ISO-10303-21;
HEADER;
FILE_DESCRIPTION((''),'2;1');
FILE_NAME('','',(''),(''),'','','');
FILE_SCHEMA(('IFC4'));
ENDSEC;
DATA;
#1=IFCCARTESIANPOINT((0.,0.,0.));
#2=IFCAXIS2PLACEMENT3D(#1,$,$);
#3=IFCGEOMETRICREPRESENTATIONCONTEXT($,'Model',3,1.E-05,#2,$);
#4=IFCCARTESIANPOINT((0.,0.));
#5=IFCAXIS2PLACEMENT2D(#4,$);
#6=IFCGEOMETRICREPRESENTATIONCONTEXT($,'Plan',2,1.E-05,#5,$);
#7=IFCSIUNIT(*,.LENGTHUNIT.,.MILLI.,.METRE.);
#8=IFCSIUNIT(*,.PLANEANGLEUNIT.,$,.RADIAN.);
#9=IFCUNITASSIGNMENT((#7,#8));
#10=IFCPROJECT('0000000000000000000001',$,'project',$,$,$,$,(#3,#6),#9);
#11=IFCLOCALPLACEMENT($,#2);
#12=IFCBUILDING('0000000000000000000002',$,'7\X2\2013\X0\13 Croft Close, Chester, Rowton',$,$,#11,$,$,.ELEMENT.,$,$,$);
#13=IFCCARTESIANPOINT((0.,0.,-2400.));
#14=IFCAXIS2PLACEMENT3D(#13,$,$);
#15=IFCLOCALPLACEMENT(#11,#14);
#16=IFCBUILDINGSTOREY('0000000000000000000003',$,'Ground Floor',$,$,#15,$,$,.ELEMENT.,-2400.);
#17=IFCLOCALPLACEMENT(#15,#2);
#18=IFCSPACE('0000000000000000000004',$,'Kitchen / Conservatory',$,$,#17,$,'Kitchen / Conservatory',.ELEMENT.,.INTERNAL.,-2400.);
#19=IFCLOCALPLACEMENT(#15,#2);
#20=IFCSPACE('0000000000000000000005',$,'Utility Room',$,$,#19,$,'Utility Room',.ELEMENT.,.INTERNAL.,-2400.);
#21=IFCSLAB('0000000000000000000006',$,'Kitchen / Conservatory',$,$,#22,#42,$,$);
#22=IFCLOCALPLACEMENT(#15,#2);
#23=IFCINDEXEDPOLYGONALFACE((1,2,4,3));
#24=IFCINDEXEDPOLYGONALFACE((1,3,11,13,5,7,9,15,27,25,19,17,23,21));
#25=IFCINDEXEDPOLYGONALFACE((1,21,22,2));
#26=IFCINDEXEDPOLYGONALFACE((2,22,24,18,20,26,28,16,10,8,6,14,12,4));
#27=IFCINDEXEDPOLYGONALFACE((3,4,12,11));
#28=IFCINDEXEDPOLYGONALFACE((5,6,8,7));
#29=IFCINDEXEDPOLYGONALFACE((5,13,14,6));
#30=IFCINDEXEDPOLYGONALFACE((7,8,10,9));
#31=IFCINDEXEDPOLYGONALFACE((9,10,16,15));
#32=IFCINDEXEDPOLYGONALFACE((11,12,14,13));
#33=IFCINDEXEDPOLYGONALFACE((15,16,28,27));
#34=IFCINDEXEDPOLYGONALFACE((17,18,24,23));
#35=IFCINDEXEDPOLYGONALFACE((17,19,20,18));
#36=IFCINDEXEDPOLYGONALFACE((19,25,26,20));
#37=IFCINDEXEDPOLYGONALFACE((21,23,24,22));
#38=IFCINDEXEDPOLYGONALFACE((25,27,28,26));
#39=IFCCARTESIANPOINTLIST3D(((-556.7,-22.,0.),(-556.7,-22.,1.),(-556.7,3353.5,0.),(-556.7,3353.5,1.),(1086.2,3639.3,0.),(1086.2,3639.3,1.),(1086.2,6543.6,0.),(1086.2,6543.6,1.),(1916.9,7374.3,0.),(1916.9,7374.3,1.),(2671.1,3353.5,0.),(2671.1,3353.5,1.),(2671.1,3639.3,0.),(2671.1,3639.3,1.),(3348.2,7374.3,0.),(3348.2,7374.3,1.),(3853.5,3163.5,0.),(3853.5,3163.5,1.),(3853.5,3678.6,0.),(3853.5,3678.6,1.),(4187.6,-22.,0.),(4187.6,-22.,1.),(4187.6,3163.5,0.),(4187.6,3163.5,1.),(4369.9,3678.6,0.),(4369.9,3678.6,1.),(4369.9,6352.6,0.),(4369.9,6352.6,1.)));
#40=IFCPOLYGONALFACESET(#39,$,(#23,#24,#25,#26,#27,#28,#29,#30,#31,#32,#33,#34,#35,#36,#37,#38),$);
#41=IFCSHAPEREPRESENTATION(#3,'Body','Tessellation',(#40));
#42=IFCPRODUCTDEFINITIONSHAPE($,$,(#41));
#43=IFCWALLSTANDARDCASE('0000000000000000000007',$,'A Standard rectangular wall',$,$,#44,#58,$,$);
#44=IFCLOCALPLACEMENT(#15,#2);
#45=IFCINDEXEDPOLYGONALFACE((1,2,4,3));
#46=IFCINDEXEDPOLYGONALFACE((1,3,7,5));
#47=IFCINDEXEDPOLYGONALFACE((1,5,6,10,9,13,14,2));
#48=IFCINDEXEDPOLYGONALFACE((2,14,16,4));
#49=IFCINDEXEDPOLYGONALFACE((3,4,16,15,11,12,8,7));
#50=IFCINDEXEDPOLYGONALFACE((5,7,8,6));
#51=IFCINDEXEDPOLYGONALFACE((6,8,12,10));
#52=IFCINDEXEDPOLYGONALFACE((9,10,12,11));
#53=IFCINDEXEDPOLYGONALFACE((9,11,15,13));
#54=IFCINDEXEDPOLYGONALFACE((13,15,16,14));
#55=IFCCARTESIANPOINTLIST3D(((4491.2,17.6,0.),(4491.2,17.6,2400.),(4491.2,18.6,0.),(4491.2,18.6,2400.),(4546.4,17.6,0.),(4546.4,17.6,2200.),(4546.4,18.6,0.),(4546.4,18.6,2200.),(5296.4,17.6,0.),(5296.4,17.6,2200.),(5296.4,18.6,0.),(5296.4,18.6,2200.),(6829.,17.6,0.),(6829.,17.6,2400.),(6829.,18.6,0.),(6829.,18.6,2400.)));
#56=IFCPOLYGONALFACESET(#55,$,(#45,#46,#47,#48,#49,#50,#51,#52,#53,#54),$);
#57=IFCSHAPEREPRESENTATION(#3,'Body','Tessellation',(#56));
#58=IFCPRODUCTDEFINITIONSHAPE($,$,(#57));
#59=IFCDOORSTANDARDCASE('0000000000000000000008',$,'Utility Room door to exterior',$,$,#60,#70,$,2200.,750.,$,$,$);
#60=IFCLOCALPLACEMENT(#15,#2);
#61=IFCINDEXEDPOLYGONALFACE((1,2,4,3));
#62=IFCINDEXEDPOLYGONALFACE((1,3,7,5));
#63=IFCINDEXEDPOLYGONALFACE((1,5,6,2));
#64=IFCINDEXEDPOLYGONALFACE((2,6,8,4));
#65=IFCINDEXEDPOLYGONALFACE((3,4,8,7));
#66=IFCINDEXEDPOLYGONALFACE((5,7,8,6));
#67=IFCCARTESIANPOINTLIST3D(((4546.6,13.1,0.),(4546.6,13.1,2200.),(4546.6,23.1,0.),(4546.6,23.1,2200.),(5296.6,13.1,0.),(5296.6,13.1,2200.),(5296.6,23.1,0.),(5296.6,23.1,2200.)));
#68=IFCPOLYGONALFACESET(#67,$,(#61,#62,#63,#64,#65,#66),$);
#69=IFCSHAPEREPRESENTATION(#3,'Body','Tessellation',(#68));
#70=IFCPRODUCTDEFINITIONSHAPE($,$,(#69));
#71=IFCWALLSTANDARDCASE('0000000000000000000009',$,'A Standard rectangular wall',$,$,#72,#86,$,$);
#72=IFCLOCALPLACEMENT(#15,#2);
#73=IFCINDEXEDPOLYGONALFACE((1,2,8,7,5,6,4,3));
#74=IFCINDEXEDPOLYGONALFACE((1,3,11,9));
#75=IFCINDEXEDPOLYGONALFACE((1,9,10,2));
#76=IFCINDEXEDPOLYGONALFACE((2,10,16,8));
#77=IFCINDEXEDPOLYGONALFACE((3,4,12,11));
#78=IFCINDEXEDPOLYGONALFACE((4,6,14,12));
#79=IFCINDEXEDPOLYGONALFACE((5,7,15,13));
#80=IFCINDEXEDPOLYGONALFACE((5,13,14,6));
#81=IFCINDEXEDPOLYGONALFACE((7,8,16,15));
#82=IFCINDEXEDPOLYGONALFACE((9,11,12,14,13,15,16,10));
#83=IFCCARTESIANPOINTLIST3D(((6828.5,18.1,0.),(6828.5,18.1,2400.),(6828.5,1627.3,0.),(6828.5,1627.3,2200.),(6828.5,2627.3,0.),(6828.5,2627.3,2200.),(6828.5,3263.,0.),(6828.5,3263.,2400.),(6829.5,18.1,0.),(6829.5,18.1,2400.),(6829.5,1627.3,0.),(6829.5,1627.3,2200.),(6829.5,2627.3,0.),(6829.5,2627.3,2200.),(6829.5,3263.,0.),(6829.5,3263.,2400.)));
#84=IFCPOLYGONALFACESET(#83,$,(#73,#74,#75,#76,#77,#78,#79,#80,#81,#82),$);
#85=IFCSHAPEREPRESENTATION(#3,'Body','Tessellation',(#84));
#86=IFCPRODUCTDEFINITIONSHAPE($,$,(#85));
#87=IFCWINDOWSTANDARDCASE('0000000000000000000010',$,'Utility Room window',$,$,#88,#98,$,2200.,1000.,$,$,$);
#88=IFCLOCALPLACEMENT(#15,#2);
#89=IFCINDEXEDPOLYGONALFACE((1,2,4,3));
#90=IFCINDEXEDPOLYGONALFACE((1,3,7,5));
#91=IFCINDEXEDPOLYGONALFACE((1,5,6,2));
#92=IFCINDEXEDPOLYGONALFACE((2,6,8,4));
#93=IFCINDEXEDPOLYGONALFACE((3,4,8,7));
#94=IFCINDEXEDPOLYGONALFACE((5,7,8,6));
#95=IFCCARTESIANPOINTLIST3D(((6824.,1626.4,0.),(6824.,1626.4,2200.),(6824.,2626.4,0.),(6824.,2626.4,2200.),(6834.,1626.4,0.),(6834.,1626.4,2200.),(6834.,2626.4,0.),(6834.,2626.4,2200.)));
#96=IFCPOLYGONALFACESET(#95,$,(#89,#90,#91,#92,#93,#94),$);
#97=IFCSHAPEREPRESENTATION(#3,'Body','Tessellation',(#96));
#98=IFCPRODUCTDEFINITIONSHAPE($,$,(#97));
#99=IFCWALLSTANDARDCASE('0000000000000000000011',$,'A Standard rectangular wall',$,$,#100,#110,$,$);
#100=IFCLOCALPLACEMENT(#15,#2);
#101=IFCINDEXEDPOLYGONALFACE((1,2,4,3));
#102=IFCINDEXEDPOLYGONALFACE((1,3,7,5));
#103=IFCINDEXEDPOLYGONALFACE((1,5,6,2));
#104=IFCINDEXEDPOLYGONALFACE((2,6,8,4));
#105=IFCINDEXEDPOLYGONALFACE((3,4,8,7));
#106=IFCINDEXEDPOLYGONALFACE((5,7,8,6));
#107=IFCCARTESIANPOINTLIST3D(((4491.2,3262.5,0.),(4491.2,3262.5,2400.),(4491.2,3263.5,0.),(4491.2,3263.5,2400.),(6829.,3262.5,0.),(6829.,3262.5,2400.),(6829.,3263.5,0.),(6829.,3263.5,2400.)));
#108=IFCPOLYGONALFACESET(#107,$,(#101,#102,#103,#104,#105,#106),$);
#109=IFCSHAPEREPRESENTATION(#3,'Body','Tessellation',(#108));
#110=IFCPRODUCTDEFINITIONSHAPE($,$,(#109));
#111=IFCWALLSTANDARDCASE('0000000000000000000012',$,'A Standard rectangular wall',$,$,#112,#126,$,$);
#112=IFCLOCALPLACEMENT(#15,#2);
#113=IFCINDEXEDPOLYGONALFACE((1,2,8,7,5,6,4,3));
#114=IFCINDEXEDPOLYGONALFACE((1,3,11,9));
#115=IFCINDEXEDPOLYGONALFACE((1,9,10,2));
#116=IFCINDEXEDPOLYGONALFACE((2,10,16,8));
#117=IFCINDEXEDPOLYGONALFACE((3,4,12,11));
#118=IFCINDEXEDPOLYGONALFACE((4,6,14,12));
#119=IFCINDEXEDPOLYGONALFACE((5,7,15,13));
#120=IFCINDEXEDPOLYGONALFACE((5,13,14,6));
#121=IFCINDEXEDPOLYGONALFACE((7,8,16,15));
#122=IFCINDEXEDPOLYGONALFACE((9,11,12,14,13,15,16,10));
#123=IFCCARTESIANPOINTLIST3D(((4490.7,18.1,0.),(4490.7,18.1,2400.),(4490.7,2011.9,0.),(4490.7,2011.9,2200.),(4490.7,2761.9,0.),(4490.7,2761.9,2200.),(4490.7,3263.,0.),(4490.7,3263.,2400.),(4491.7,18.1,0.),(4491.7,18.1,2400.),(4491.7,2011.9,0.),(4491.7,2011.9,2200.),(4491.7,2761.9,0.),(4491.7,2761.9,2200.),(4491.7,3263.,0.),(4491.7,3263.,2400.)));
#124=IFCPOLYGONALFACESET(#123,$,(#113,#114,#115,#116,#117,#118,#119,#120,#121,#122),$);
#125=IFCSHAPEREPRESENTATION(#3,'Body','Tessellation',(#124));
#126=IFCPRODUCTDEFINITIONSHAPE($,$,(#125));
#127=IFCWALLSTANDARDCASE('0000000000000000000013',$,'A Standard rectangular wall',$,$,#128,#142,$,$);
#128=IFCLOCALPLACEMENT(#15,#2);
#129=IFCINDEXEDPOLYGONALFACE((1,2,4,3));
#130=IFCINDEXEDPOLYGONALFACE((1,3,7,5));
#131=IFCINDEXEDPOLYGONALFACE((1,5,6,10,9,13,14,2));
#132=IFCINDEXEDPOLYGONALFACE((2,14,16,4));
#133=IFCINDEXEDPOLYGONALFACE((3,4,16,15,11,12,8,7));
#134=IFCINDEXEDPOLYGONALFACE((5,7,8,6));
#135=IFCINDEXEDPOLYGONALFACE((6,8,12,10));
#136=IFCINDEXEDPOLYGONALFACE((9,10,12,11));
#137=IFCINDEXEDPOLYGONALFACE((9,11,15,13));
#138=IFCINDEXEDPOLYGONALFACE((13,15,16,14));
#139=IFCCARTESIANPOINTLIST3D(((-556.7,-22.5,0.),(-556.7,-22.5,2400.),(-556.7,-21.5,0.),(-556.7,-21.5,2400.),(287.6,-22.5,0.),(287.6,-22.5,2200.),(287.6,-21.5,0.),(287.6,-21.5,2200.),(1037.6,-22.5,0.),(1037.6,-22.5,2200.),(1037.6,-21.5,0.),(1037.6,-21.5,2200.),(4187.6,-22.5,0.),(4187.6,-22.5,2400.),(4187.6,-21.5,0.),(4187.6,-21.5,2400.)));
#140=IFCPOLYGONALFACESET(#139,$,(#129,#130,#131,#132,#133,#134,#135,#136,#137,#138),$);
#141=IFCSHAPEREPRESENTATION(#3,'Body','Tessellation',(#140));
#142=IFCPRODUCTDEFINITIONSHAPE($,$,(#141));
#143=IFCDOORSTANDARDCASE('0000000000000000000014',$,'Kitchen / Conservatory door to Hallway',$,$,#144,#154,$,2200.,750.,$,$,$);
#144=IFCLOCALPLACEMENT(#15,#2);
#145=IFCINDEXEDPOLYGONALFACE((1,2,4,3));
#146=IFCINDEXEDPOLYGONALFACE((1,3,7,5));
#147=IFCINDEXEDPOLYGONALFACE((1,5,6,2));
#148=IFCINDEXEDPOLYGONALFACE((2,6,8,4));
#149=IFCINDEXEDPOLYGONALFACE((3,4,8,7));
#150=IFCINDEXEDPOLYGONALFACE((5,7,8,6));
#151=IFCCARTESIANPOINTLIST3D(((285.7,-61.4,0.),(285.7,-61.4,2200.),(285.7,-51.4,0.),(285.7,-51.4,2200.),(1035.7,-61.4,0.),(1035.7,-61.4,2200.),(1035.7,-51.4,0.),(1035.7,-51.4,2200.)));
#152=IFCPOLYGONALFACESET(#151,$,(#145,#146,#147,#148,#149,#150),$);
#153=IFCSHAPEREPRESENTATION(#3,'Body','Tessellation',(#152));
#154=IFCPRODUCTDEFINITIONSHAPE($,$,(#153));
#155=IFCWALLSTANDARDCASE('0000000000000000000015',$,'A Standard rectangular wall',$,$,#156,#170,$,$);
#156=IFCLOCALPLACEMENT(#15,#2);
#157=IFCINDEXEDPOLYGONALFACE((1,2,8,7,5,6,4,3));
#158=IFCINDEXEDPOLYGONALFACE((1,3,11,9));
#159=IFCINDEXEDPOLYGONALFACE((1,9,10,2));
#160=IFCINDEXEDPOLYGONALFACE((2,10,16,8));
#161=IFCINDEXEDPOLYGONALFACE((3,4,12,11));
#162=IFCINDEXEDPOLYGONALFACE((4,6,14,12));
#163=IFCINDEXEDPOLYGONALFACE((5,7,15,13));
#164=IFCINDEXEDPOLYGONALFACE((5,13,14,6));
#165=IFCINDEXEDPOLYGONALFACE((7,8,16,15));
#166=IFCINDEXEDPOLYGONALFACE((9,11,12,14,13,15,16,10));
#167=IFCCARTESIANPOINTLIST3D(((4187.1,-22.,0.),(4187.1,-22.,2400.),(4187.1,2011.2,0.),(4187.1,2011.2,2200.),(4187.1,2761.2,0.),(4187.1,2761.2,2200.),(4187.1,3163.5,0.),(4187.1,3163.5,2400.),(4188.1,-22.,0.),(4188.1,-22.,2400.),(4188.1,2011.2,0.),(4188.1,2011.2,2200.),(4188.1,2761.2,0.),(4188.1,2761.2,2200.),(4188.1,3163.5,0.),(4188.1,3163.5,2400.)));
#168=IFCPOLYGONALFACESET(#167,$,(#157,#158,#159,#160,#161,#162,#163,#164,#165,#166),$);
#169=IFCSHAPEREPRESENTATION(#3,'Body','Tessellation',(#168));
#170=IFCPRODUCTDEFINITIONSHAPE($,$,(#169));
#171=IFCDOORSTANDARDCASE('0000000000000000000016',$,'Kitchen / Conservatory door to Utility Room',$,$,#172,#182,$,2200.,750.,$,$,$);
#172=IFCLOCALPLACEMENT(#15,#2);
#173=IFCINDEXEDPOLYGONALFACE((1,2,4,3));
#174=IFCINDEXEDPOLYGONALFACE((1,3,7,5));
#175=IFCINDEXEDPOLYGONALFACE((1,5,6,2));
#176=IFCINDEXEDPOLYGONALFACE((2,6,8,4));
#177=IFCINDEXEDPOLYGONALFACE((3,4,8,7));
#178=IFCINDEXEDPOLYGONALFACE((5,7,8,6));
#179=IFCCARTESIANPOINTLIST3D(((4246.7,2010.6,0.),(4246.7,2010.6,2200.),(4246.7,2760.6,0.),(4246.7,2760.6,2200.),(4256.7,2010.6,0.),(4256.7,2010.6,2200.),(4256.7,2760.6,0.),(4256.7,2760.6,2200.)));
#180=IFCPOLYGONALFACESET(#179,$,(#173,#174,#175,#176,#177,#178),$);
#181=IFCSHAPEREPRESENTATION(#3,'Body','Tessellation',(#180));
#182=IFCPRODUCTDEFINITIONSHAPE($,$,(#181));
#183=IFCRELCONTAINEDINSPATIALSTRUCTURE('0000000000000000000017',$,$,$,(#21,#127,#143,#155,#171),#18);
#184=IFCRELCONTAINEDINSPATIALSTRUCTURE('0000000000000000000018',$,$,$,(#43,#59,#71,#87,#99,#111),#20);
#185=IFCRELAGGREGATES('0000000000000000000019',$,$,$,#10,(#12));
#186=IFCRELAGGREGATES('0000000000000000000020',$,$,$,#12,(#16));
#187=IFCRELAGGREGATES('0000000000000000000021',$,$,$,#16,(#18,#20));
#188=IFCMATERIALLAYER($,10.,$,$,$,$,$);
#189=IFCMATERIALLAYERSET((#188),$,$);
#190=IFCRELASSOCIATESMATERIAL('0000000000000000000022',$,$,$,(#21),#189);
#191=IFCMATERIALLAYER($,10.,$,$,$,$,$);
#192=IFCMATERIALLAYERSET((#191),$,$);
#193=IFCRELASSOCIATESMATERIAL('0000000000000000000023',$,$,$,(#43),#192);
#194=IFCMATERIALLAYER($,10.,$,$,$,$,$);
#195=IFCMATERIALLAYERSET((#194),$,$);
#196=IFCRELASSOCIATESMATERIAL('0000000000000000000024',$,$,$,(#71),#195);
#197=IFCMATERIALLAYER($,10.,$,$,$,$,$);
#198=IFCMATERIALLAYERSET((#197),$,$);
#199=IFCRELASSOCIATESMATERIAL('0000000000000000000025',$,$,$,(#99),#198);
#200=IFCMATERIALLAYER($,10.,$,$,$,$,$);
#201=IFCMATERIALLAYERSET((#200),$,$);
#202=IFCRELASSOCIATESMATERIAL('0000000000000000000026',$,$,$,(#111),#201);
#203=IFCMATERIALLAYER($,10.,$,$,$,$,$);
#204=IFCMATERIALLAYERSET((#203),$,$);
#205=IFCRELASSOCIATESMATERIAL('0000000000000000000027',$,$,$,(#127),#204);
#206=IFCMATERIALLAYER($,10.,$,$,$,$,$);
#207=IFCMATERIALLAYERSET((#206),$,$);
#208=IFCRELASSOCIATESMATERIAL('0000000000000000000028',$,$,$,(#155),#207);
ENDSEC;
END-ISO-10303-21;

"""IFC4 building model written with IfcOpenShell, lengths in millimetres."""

from ifc_helpers import new_model, si_unit, frame, origin, origin_2d, place, context, project, spatial, polyline, rectangle, outline, extrude, layer, layer_set, layer_usage, element, fill, save


model = new_model("IFC4")

# Units and contexts
model_context = context("Model", 3, precision=1e-05, world=origin())
plan_context = context("Plan", 2, precision=1e-05, world=origin_2d())
ifc_project = project(units=[si_unit("LENGTHUNIT", "METRE", prefix="MILLI"), si_unit("PLANEANGLEUNIT", "RADIAN")], contexts=[model_context, plan_context])

# Building, storey, space
building_placement = place(None, origin())
building = spatial("IfcBuilding", under=ifc_project, at=building_placement, Name="7–13 Croft Close, Chester, Rowton", CompositionType="ELEMENT")
storey_placement = place(building_placement, frame((0.0, 0.0, -2400.0)))
storey = spatial("IfcBuildingStorey", under=building, at=storey_placement, Name="Ground Floor", CompositionType="ELEMENT", Elevation=-2400.0)
space_1_placement = place(storey_placement, origin())
space_1 = spatial("IfcSpace", under=storey, at=space_1_placement, Name="Kitchen / Conservatory", LongName="Kitchen / Conservatory", CompositionType="ELEMENT", PredefinedType="INTERNAL", ElevationWithFlooring=-2400.0)

# Slab
ifc_layer_1 = layer(None, 10.0)
ifc_layer_set_1 = layer_set([ifc_layer_1])
ifc_layer_usage_1 = layer_usage(ifc_layer_set_1, "AXIS2", "NEGATIVE", 150.0)
slab_placement = place(storey_placement, origin())
element("IfcSlab", 1, at=slab_placement, inside=space_1, material=ifc_layer_usage_1, Name="Kitchen / Conservatory", context=model_context, shape_type="SweptSolid", body=[
    extrude(outline(polyline([(-556.7, -22.0), (4187.6, -22.0), (4187.6, 3163.5), (3853.5, 3163.5), (3853.5, 3678.6), (4369.9, 3678.6), (4369.9, 6352.6), (3348.2, 7374.3), (1916.9, 7374.3), (1086.2, 6543.6), (1086.2, 3639.3), (2671.1, 3639.3), (2671.1, 3353.5), (-556.7, 3353.5), (-556.7, -22.0)])), origin(), (0.0, 0.0, 1.0), 1.0),
])

# Shared definitions
space_2_placement = place(storey_placement, origin())
space_2 = spatial("IfcSpace", under=storey, at=space_2_placement, Name="Utility Room", LongName="Utility Room", CompositionType="ELEMENT", PredefinedType="INTERNAL", ElevationWithFlooring=-2400.0)

# Wall, opening, door
ifc_layer_2 = layer(None, 10.0)
ifc_layer_set_2 = layer_set([ifc_layer_2])
ifc_layer_usage_2 = layer_usage(ifc_layer_set_2, "AXIS2", "NEGATIVE", 150.0)
wall_1_placement = place(storey_placement, origin())
wall_1 = element("IfcWallStandardCase", 2, at=wall_1_placement, inside=space_2, material=ifc_layer_usage_2, Name="A Standard rectangular wall", context=model_context, shape_type="SweptSolid", body=[
    extrude(rectangle(XDim=1.0, YDim=2337.8, at=origin_2d()), frame((5660.1, 18.1, 0.0), x_axis=(0.0, 1.0, 0.0)), (0.0, 0.0, 1.0), 2400.0),
])
opening_1_placement = place(storey_placement, origin())
opening_1 = element("IfcOpeningElement", 3, at=opening_1_placement, cuts=wall_1, context=model_context, shape_type="SweptSolid", body=[
    extrude(rectangle(XDim=10.0, YDim=750.0, at=origin_2d()), frame((4921.4, 18.1, 0.0), x_axis=(0.0, -1.0, 0.0)), (0.0, 0.0, 1.0), 2200.0),
])
door_1_placement = place(storey_placement, frame((0.2, 0.0, 0.0)))
door_1 = element("IfcDoorStandardCase", 4, at=door_1_placement, inside=space_2, Name="Utility Room door to exterior", OverallHeight=2200.0, OverallWidth=750.0, context=model_context, shape_type="SweptSolid", body=[
    extrude(rectangle(XDim=10.0, YDim=750.0, at=origin_2d()), frame((4921.4, 18.1, 0.0), x_axis=(0.0, -1.0, 0.0)), (0.0, 0.0, 1.0), 2200.0),
])
fill(opening_1, door_1)

# Wall, opening, window
ifc_layer_3 = layer(None, 10.0)
ifc_layer_set_3 = layer_set([ifc_layer_3])
ifc_layer_usage_3 = layer_usage(ifc_layer_set_3, "AXIS2", "NEGATIVE", 150.0)
wall_2_placement = place(storey_placement, origin())
wall_2 = element("IfcWallStandardCase", 5, at=wall_2_placement, inside=space_2, material=ifc_layer_usage_3, Name="A Standard rectangular wall", context=model_context, shape_type="SweptSolid", body=[
    extrude(rectangle(XDim=1.0, YDim=3244.9, at=origin_2d()), frame((6829.0, 1640.6, 0.0), x_axis=(-1.0, 0.0, 0.0)), (0.0, 0.0, 1.0), 2400.0),
])
opening_2_placement = place(storey_placement, origin())
opening_2 = element("IfcOpeningElement", 6, at=opening_2_placement, cuts=wall_2, context=model_context, shape_type="SweptSolid", body=[
    extrude(rectangle(XDim=10.0, YDim=1000.0, at=origin_2d()), frame((6829.0, 2127.3, 0.0), x_axis=(1.0, 0.0, 0.0)), (0.0, 0.0, 1.0), 2200.0),
])
window_placement = place(storey_placement, frame((0.0, -0.9, 0.0)))
window = element("IfcWindowStandardCase", 7, at=window_placement, inside=space_2, Name="Utility Room window", OverallHeight=2200.0, OverallWidth=1000.0, context=model_context, shape_type="SweptSolid", body=[
    extrude(rectangle(XDim=10.0, YDim=1000.0, at=origin_2d()), frame((6829.0, 2127.3, 0.0), x_axis=(1.0, 0.0, 0.0)), (0.0, 0.0, 1.0), 2200.0),
])
fill(opening_2, window)

# Wall
ifc_layer_4 = layer(None, 10.0)
ifc_layer_set_4 = layer_set([ifc_layer_4])
ifc_layer_usage_4 = layer_usage(ifc_layer_set_4, "AXIS2", "NEGATIVE", 150.0)
wall_3_placement = place(storey_placement, origin())
element("IfcWallStandardCase", 8, at=wall_3_placement, inside=space_2, material=ifc_layer_usage_4, Name="A Standard rectangular wall", context=model_context, shape_type="SweptSolid", body=[
    extrude(rectangle(XDim=1.0, YDim=2337.8, at=origin_2d()), frame((5660.1, 3263.0, 0.0), x_axis=(0.0, -1.0, 0.0)), (0.0, 0.0, 1.0), 2400.0),
])

# Wall, opening
ifc_layer_5 = layer(None, 10.0)
ifc_layer_set_5 = layer_set([ifc_layer_5])
ifc_layer_usage_5 = layer_usage(ifc_layer_set_5, "AXIS2", "NEGATIVE", 150.0)
wall_4_placement = place(storey_placement, origin())
wall_4 = element("IfcWallStandardCase", 9, at=wall_4_placement, inside=space_2, material=ifc_layer_usage_5, Name="A Standard rectangular wall", context=model_context, shape_type="SweptSolid", body=[
    extrude(rectangle(XDim=1.0, YDim=3244.9, at=origin_2d()), frame((4491.2, 1640.6, 0.0), x_axis=(1.0, 0.0, 0.0)), (0.0, 0.0, 1.0), 2400.0),
])
opening_3_placement = place(storey_placement, origin())
element("IfcOpeningElement", 10, at=opening_3_placement, cuts=wall_4, context=model_context, shape_type="SweptSolid", body=[
    extrude(rectangle(XDim=10.0, YDim=750.0, at=origin_2d()), frame((4491.2, 2386.9, 0.0), x_axis=(-1.0, 0.0, 0.0)), (0.0, 0.0, 1.0), 2200.0),
])

# Walls, openings, doors
ifc_layer_6 = layer(None, 10.0)
ifc_layer_set_6 = layer_set([ifc_layer_6])
ifc_layer_usage_6 = layer_usage(ifc_layer_set_6, "AXIS2", "NEGATIVE", 150.0)
wall_5_placement = place(storey_placement, origin())
wall_5 = element("IfcWallStandardCase", 11, at=wall_5_placement, inside=space_1, material=ifc_layer_usage_6, Name="A Standard rectangular wall", context=model_context, shape_type="SweptSolid", body=[
    extrude(rectangle(XDim=1.0, YDim=4744.3, at=origin_2d()), frame((1815.5, -22.0, 0.0), x_axis=(0.0, 1.0, 0.0)), (0.0, 0.0, 1.0), 2400.0),
])
opening_4_placement = place(storey_placement, origin())
opening_4 = element("IfcOpeningElement", 12, at=opening_4_placement, cuts=wall_5, context=model_context, shape_type="SweptSolid", body=[
    extrude(rectangle(XDim=10.0, YDim=750.0, at=origin_2d()), frame((662.6, -22.0, 0.0), x_axis=(0.0, -1.0, 0.0)), (0.0, 0.0, 1.0), 2200.0),
])
door_2_placement = place(storey_placement, frame((-1.9, -34.4, 0.0)))
door_2 = element("IfcDoorStandardCase", 13, at=door_2_placement, inside=space_1, Name="Kitchen / Conservatory door to Hallway", OverallHeight=2200.0, OverallWidth=750.0, context=model_context, shape_type="SweptSolid", body=[
    extrude(rectangle(XDim=10.0, YDim=750.0, at=origin_2d()), frame((662.6, -22.0, 0.0), x_axis=(0.0, -1.0, 0.0)), (0.0, 0.0, 1.0), 2200.0),
])
fill(opening_4, door_2)
ifc_layer_7 = layer(None, 10.0)
ifc_layer_set_7 = layer_set([ifc_layer_7])
ifc_layer_usage_7 = layer_usage(ifc_layer_set_7, "AXIS2", "NEGATIVE", 150.0)
wall_6_placement = place(storey_placement, origin())
wall_6 = element("IfcWallStandardCase", 14, at=wall_6_placement, inside=space_1, material=ifc_layer_usage_7, Name="A Standard rectangular wall", context=model_context, shape_type="SweptSolid", body=[
    extrude(rectangle(XDim=1.0, YDim=3185.5, at=origin_2d()), frame((4187.6, 1570.8, 0.0), x_axis=(-1.0, 0.0, 0.0)), (0.0, 0.0, 1.0), 2400.0),
])
opening_5_placement = place(storey_placement, origin())
opening_5 = element("IfcOpeningElement", 15, at=opening_5_placement, cuts=wall_6, context=model_context, shape_type="SweptSolid", body=[
    extrude(rectangle(XDim=10.0, YDim=750.0, at=origin_2d()), frame((4187.6, 2386.2, 0.0), x_axis=(-1.0, 0.0, 0.0)), (0.0, 0.0, 1.0), 2200.0),
])
door_3_placement = place(storey_placement, frame((64.1, -0.6, 0.0)))
door_3 = element("IfcDoorStandardCase", 16, at=door_3_placement, inside=space_1, Name="Kitchen / Conservatory door to Utility Room", OverallHeight=2200.0, OverallWidth=750.0, context=model_context, shape_type="SweptSolid", body=[
    extrude(rectangle(XDim=10.0, YDim=750.0, at=origin_2d()), frame((4187.6, 2386.2, 0.0), x_axis=(-1.0, 0.0, 0.0)), (0.0, 0.0, 1.0), 2200.0),
])
fill(opening_5, door_3)

save(model, "model.ifc")
